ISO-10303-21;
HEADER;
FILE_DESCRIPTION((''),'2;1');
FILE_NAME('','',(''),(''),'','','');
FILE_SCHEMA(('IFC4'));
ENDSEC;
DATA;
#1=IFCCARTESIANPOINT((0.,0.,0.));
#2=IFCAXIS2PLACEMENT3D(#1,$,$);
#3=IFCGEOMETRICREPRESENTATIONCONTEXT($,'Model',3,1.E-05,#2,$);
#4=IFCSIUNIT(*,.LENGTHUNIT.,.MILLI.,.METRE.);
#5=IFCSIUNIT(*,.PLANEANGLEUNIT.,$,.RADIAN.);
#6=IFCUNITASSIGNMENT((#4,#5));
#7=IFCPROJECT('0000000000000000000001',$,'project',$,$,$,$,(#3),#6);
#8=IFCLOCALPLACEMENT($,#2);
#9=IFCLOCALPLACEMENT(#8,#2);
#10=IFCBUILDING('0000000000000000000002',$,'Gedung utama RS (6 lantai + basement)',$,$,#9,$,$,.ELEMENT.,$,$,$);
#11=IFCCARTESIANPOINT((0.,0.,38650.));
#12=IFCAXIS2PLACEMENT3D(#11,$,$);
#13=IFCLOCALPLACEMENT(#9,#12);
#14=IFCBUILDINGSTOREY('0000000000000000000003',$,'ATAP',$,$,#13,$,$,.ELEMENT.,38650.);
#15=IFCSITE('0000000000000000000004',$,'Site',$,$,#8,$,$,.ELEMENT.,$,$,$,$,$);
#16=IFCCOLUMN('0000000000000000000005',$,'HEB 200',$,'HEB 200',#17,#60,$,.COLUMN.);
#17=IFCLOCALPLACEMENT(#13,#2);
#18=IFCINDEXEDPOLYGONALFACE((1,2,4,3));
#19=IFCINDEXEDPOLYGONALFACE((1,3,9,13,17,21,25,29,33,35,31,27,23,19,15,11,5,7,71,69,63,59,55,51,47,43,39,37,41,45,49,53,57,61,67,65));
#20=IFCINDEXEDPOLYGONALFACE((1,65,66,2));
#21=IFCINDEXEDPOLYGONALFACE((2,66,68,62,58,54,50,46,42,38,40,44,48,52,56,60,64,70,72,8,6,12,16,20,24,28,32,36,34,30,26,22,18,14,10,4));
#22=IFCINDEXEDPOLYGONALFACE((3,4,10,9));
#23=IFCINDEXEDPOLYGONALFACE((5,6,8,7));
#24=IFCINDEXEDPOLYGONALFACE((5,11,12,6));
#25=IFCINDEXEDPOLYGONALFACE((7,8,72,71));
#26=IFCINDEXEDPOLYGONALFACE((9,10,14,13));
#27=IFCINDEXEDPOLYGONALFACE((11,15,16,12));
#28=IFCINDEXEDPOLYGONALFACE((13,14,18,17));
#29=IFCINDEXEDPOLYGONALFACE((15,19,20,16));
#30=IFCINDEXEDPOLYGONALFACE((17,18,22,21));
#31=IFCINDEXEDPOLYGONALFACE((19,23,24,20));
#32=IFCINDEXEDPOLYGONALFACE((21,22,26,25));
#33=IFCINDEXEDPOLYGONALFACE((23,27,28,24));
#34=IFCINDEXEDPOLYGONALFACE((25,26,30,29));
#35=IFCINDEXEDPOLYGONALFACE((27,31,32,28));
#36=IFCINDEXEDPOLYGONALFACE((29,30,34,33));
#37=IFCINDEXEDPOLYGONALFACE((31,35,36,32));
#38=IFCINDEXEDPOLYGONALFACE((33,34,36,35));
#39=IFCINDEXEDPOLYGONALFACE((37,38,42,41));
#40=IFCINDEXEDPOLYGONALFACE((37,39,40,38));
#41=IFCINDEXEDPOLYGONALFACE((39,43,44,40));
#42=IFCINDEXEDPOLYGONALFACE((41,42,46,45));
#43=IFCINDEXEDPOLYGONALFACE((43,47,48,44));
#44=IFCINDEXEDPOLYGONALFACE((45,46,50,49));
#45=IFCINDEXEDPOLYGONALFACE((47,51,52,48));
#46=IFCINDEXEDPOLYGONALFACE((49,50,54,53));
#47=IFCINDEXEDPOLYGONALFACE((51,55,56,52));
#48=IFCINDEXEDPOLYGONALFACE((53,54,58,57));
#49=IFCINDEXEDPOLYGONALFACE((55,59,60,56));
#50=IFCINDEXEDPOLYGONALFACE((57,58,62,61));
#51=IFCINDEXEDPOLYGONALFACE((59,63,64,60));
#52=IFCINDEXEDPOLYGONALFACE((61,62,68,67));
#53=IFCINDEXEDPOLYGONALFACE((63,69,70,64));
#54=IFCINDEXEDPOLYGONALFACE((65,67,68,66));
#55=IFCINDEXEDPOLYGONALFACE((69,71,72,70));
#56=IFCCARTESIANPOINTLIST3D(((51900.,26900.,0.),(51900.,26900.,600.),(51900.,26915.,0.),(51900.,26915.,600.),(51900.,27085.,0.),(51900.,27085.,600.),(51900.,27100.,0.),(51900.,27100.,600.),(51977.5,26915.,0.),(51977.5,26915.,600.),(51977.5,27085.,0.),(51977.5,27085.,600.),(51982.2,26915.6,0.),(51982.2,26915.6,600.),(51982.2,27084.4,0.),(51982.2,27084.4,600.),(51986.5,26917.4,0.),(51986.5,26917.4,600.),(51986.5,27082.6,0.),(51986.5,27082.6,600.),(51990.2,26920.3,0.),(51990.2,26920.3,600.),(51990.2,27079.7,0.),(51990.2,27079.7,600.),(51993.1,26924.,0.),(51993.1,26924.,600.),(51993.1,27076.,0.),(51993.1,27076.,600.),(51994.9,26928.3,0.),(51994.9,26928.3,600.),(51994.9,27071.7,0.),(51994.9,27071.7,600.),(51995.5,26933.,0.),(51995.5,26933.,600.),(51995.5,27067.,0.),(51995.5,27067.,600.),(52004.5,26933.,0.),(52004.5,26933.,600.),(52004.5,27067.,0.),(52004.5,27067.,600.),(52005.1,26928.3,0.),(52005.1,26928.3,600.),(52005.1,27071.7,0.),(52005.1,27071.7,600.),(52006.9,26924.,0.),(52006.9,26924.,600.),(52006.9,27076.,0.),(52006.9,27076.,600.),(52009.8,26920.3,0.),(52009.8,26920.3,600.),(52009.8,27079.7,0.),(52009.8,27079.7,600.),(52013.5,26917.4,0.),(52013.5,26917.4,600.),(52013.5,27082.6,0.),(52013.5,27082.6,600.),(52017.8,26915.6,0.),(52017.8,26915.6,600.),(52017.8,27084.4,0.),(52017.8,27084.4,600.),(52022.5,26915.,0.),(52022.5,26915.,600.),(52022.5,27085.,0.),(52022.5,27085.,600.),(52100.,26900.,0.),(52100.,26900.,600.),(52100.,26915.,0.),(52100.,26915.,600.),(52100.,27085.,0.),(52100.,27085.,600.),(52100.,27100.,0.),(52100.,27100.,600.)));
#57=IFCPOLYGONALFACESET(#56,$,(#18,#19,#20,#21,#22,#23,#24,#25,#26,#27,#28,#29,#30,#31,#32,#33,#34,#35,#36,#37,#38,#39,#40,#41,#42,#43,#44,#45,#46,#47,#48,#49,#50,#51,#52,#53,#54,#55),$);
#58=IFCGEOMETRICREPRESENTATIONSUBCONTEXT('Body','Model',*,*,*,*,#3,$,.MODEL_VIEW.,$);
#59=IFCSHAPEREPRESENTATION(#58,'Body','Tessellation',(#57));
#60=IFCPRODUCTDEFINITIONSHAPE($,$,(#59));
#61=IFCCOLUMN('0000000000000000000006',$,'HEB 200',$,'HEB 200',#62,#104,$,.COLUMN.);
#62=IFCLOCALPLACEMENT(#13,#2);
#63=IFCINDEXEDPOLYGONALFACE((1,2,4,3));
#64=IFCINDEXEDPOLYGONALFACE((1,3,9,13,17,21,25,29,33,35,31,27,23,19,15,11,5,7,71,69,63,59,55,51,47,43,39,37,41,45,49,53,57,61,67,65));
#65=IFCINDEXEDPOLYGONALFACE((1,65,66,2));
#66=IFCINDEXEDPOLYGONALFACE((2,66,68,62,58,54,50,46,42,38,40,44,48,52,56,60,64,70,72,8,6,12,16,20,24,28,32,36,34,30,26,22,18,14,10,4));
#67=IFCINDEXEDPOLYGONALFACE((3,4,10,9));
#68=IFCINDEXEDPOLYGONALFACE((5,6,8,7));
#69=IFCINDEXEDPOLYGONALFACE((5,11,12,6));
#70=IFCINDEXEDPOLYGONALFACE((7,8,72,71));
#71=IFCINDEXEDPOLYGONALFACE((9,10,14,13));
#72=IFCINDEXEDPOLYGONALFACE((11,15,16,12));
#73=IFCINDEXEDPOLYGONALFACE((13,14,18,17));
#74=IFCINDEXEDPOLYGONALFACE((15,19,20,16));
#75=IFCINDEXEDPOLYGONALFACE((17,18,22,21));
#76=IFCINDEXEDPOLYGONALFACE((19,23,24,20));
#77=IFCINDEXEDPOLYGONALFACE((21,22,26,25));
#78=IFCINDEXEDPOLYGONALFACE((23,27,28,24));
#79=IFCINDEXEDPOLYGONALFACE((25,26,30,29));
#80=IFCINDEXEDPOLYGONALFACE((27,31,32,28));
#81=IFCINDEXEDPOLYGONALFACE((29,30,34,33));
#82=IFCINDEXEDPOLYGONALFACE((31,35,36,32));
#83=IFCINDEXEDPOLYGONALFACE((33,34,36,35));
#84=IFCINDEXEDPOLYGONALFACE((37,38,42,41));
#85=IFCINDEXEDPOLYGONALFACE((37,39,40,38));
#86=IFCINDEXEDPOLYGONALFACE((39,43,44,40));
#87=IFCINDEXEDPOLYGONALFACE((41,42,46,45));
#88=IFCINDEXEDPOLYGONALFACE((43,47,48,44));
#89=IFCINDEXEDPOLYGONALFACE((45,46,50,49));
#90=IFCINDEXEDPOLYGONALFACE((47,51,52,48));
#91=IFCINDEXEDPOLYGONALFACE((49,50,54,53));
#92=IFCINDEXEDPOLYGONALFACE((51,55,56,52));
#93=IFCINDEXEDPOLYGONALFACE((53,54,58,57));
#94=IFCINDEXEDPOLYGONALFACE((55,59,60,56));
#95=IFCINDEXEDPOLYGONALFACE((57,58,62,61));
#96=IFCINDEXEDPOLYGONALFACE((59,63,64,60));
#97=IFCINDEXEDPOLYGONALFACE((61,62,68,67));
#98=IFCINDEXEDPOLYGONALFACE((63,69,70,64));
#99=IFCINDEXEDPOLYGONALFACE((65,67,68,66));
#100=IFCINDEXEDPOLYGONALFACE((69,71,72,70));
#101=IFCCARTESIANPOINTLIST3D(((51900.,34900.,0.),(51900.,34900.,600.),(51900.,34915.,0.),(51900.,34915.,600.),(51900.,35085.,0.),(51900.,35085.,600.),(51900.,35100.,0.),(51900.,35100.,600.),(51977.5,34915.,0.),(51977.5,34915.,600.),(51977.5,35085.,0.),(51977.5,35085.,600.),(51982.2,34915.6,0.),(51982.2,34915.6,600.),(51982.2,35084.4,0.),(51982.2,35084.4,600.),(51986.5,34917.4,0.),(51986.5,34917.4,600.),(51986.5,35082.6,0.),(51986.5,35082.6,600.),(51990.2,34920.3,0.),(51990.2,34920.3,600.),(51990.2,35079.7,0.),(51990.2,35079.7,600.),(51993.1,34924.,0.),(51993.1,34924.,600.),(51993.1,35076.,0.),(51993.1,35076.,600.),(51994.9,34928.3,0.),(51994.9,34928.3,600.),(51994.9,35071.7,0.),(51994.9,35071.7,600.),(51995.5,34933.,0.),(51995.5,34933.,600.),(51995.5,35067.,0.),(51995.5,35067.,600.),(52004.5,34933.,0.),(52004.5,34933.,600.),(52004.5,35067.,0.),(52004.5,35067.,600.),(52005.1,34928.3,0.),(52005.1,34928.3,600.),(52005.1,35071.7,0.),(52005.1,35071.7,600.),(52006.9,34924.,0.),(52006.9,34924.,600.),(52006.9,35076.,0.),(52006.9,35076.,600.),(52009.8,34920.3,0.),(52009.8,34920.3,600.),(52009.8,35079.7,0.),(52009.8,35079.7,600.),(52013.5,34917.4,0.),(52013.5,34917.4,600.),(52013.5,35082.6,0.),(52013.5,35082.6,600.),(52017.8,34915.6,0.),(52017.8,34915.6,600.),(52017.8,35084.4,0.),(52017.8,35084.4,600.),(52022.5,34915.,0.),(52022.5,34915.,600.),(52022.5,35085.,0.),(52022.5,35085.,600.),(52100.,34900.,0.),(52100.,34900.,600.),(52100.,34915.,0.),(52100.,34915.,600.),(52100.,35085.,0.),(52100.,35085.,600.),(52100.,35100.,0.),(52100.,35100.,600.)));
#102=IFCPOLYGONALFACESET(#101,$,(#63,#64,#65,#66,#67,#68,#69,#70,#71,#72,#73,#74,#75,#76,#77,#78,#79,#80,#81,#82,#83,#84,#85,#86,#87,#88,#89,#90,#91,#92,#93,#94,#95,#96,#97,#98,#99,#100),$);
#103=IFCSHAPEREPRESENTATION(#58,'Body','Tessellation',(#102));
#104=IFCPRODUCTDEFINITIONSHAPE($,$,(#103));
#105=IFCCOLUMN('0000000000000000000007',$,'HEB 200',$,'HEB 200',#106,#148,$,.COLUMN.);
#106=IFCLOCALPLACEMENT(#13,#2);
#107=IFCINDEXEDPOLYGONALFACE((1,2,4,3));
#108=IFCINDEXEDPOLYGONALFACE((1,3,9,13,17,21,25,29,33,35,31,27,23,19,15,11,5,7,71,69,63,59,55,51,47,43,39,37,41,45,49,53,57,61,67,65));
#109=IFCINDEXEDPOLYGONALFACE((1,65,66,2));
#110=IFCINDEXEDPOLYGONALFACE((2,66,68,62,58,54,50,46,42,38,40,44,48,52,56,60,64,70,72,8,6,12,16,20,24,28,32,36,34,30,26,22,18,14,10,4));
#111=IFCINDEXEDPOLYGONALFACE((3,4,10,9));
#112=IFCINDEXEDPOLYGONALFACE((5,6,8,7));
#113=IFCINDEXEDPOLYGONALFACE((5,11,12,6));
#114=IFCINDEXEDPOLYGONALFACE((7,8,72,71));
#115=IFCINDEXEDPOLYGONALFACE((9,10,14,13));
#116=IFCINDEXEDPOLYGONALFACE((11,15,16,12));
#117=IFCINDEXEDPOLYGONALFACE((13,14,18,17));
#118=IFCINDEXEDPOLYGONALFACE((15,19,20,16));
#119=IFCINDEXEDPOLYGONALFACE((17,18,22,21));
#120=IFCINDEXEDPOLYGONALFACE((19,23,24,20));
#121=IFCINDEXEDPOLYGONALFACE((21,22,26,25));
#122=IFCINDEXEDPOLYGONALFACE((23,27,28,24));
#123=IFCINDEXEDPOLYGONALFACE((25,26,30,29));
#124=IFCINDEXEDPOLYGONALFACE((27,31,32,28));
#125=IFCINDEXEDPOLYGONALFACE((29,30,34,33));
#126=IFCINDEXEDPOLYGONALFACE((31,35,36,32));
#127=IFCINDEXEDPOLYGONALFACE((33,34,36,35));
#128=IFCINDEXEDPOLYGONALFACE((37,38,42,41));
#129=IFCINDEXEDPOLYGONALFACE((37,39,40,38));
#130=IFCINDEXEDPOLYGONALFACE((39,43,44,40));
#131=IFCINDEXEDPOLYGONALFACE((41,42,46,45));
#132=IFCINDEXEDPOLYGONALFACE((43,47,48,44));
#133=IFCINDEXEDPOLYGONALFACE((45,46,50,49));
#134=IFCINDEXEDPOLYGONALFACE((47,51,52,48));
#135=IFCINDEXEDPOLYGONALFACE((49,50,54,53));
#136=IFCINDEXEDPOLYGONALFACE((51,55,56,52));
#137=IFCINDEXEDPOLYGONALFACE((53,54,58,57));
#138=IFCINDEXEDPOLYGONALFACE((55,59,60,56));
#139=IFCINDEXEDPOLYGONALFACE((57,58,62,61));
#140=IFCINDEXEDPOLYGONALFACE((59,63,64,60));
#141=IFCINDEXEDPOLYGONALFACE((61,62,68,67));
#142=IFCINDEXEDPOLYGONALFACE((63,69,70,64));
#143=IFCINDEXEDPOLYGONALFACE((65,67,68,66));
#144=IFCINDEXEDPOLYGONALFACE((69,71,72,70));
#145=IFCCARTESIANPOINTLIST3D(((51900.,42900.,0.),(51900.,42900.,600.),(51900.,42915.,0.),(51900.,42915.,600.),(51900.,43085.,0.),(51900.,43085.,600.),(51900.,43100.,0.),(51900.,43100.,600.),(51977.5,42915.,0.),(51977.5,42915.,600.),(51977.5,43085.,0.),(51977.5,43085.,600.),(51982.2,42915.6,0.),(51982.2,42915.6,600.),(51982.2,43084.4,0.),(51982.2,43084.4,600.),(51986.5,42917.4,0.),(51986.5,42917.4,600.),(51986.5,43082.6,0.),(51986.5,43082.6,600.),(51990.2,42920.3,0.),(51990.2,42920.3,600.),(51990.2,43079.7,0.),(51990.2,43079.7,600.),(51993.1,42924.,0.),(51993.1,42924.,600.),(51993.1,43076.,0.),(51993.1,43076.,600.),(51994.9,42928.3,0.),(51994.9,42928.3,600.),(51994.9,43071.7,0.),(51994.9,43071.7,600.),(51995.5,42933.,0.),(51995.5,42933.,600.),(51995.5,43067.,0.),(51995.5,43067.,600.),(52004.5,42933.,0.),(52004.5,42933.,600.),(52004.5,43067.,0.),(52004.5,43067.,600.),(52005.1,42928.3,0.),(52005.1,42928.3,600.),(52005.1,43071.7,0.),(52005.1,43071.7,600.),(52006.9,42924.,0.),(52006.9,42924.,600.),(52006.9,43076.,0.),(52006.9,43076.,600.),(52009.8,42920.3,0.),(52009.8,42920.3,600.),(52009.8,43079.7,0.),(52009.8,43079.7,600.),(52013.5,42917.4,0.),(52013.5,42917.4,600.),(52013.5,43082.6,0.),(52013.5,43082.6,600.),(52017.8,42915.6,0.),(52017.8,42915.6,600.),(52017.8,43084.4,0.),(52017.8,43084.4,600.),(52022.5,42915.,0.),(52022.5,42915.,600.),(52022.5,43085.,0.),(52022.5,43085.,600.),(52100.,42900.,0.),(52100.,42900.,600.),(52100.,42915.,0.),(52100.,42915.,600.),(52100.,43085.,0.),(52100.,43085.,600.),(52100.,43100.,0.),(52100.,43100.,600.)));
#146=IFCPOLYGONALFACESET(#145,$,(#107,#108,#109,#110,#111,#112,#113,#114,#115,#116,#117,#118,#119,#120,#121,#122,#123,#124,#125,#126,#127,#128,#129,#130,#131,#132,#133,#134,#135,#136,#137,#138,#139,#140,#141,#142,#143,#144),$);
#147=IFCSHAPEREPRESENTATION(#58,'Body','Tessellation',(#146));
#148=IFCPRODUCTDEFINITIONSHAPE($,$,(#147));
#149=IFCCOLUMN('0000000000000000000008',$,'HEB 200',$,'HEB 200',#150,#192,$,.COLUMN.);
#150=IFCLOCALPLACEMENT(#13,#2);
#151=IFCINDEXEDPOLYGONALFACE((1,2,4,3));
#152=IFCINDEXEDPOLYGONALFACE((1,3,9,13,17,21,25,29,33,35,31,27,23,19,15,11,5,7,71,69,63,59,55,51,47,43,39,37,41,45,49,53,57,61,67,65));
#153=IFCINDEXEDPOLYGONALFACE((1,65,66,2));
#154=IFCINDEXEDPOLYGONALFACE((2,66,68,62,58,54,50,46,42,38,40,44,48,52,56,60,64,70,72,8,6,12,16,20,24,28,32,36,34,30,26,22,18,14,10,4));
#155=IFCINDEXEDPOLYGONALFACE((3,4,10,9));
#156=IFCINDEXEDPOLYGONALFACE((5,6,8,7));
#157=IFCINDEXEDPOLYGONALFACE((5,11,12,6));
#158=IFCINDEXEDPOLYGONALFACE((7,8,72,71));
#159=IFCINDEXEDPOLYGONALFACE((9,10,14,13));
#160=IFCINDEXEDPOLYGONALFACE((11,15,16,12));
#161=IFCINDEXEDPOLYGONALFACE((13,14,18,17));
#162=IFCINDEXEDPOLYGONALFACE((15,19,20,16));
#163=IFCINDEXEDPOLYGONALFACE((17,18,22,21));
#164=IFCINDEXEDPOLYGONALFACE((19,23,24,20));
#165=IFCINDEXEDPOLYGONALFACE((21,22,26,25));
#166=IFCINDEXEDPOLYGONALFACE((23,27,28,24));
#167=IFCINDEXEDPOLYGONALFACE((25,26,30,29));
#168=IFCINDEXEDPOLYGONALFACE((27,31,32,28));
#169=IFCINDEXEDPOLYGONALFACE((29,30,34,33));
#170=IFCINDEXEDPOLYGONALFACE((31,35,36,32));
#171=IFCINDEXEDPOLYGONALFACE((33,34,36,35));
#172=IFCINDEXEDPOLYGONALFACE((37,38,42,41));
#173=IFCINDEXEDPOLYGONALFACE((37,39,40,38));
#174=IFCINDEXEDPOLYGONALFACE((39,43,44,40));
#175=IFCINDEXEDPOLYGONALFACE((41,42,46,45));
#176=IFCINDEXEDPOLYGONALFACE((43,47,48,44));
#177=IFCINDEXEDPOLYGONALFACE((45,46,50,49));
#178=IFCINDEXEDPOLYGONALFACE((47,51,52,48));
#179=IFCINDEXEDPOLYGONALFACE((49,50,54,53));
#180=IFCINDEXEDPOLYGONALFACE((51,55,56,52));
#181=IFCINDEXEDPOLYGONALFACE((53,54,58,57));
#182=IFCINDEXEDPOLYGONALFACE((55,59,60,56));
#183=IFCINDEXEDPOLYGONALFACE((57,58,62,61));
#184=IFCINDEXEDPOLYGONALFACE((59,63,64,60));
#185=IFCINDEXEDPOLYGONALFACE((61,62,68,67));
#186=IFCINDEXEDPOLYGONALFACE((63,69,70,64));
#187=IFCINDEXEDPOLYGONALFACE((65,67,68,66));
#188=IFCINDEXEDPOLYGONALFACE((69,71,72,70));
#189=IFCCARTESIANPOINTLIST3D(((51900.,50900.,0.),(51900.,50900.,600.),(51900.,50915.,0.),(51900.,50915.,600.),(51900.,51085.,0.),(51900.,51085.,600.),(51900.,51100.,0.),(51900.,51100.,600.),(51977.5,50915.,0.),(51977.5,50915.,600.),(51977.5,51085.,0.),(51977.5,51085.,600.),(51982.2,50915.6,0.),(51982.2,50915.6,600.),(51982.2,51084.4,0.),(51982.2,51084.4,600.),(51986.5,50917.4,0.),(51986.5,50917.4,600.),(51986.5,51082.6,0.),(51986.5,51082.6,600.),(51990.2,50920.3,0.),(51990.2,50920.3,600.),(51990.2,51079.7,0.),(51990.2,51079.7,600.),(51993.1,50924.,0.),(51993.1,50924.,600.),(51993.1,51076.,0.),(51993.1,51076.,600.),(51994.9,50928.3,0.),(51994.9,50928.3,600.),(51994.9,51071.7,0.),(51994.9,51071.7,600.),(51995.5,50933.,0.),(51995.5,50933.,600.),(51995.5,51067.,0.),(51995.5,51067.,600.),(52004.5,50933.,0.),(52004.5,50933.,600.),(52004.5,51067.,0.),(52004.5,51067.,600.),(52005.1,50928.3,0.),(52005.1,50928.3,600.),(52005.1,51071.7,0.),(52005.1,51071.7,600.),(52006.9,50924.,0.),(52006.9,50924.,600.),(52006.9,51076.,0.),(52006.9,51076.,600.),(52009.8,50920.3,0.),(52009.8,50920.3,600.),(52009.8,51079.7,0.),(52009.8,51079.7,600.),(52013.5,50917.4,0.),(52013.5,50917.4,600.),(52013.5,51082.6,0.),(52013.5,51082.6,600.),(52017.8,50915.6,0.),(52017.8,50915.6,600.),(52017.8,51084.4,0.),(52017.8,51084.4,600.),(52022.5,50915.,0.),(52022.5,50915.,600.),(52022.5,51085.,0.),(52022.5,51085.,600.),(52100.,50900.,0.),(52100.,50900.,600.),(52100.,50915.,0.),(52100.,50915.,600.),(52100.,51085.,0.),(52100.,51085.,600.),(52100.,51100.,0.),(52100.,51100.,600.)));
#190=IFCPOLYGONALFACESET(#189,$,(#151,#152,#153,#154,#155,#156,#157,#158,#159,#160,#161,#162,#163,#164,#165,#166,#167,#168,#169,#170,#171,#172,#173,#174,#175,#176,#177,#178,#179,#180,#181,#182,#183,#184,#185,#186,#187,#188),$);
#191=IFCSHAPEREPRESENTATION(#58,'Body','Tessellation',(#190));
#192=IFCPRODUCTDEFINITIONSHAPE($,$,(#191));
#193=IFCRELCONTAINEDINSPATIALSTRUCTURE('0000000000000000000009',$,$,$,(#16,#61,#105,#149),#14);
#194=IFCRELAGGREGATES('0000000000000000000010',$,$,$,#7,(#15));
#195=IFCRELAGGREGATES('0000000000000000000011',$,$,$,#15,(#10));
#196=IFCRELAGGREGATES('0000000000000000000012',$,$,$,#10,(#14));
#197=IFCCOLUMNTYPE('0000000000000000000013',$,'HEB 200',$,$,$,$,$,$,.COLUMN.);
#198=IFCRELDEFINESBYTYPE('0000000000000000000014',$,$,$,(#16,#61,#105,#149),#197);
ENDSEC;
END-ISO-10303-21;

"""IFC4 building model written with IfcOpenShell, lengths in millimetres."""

from ifc_helpers import new_model, si_unit, frame, origin, origin_2d, place, context, subcontext, project, spatial, i_section, extrude, material_profile, profile_set, profile_usage, type_object, element, save


model = new_model("IFC4")

# Units and contexts
model_context = context("Model", 3, precision=1e-05, world=origin())
body_context = subcontext(model_context, "Body", "Model", "MODEL_VIEW")
ifc_project = project(units=[si_unit("LENGTHUNIT", "METRE", prefix="MILLI"), si_unit("PLANEANGLEUNIT", "RADIAN")], contexts=[model_context])

# Site, building, storey
site_placement = place(None, origin())
site = spatial("IfcSite", under=ifc_project, at=site_placement, Name="Site", CompositionType="ELEMENT")
building_placement = place(site_placement, origin())
building = spatial("IfcBuilding", under=site, at=building_placement, Name="Gedung utama RS (6 lantai + basement)", CompositionType="ELEMENT")
storey_placement = place(building_placement, frame((0.0, 0.0, 38650.0)))
storey = spatial("IfcBuildingStorey", under=building, at=storey_placement, Name="ATAP", CompositionType="ELEMENT", Elevation=38650.0)

# Columns
ifc_material_profile_1 = material_profile(None, i_section(OverallWidth=200.0, OverallDepth=200.0, WebThickness=9.0, FlangeThickness=15.0, FilletRadius=18.0, at=origin_2d()), Name="HEB 200")
ifc_profile_set_1 = profile_set([ifc_material_profile_1], Name="HEB 200")
ifc_profile_usage_1 = profile_usage(ifc_profile_set_1, cardinal=5)
column_type = type_object("IfcColumnType", Name="HEB 200", PredefinedType="COLUMN", material=ifc_profile_set_1)
for number, where, z_axis, x_axis, name in (
    (1, (52000.0, 27000.0, 0.0), (0.0, 0.0, 1.0), (1.0, 0.0, 0.0), "HEB 200"),
    (2, (52000.0, 35000.0, 0.0), (0.0, 0.0, 1.0), (1.0, 0.0, 0.0), "HEB 200"),
    (3, (52000.0, 43000.0, 0.0), (0.0, 0.0, 1.0), (1.0, 0.0, 0.0), "HEB 200"),
    (4, (52000.0, 51000.0, 0.0), (0.0, 0.0, 1.0), (1.0, 0.0, 0.0), "HEB 200"),
):
    element("IfcColumn", number, at=place(storey_placement, frame(where, z_axis=z_axis, x_axis=x_axis)), inside=storey, type_object=column_type, material=ifc_profile_usage_1, Name=name, ObjectType="HEB 200", PredefinedType="COLUMN", context=body_context, shape_type="SweptSolid", body=[
        extrude(i_section(OverallWidth=200.0, OverallDepth=200.0, WebThickness=9.0, FlangeThickness=15.0, FilletRadius=18.0, at=origin_2d()), origin(), (0.0, 0.0, 1.0), 600.0),
    ])

save(model, "model.ifc")
